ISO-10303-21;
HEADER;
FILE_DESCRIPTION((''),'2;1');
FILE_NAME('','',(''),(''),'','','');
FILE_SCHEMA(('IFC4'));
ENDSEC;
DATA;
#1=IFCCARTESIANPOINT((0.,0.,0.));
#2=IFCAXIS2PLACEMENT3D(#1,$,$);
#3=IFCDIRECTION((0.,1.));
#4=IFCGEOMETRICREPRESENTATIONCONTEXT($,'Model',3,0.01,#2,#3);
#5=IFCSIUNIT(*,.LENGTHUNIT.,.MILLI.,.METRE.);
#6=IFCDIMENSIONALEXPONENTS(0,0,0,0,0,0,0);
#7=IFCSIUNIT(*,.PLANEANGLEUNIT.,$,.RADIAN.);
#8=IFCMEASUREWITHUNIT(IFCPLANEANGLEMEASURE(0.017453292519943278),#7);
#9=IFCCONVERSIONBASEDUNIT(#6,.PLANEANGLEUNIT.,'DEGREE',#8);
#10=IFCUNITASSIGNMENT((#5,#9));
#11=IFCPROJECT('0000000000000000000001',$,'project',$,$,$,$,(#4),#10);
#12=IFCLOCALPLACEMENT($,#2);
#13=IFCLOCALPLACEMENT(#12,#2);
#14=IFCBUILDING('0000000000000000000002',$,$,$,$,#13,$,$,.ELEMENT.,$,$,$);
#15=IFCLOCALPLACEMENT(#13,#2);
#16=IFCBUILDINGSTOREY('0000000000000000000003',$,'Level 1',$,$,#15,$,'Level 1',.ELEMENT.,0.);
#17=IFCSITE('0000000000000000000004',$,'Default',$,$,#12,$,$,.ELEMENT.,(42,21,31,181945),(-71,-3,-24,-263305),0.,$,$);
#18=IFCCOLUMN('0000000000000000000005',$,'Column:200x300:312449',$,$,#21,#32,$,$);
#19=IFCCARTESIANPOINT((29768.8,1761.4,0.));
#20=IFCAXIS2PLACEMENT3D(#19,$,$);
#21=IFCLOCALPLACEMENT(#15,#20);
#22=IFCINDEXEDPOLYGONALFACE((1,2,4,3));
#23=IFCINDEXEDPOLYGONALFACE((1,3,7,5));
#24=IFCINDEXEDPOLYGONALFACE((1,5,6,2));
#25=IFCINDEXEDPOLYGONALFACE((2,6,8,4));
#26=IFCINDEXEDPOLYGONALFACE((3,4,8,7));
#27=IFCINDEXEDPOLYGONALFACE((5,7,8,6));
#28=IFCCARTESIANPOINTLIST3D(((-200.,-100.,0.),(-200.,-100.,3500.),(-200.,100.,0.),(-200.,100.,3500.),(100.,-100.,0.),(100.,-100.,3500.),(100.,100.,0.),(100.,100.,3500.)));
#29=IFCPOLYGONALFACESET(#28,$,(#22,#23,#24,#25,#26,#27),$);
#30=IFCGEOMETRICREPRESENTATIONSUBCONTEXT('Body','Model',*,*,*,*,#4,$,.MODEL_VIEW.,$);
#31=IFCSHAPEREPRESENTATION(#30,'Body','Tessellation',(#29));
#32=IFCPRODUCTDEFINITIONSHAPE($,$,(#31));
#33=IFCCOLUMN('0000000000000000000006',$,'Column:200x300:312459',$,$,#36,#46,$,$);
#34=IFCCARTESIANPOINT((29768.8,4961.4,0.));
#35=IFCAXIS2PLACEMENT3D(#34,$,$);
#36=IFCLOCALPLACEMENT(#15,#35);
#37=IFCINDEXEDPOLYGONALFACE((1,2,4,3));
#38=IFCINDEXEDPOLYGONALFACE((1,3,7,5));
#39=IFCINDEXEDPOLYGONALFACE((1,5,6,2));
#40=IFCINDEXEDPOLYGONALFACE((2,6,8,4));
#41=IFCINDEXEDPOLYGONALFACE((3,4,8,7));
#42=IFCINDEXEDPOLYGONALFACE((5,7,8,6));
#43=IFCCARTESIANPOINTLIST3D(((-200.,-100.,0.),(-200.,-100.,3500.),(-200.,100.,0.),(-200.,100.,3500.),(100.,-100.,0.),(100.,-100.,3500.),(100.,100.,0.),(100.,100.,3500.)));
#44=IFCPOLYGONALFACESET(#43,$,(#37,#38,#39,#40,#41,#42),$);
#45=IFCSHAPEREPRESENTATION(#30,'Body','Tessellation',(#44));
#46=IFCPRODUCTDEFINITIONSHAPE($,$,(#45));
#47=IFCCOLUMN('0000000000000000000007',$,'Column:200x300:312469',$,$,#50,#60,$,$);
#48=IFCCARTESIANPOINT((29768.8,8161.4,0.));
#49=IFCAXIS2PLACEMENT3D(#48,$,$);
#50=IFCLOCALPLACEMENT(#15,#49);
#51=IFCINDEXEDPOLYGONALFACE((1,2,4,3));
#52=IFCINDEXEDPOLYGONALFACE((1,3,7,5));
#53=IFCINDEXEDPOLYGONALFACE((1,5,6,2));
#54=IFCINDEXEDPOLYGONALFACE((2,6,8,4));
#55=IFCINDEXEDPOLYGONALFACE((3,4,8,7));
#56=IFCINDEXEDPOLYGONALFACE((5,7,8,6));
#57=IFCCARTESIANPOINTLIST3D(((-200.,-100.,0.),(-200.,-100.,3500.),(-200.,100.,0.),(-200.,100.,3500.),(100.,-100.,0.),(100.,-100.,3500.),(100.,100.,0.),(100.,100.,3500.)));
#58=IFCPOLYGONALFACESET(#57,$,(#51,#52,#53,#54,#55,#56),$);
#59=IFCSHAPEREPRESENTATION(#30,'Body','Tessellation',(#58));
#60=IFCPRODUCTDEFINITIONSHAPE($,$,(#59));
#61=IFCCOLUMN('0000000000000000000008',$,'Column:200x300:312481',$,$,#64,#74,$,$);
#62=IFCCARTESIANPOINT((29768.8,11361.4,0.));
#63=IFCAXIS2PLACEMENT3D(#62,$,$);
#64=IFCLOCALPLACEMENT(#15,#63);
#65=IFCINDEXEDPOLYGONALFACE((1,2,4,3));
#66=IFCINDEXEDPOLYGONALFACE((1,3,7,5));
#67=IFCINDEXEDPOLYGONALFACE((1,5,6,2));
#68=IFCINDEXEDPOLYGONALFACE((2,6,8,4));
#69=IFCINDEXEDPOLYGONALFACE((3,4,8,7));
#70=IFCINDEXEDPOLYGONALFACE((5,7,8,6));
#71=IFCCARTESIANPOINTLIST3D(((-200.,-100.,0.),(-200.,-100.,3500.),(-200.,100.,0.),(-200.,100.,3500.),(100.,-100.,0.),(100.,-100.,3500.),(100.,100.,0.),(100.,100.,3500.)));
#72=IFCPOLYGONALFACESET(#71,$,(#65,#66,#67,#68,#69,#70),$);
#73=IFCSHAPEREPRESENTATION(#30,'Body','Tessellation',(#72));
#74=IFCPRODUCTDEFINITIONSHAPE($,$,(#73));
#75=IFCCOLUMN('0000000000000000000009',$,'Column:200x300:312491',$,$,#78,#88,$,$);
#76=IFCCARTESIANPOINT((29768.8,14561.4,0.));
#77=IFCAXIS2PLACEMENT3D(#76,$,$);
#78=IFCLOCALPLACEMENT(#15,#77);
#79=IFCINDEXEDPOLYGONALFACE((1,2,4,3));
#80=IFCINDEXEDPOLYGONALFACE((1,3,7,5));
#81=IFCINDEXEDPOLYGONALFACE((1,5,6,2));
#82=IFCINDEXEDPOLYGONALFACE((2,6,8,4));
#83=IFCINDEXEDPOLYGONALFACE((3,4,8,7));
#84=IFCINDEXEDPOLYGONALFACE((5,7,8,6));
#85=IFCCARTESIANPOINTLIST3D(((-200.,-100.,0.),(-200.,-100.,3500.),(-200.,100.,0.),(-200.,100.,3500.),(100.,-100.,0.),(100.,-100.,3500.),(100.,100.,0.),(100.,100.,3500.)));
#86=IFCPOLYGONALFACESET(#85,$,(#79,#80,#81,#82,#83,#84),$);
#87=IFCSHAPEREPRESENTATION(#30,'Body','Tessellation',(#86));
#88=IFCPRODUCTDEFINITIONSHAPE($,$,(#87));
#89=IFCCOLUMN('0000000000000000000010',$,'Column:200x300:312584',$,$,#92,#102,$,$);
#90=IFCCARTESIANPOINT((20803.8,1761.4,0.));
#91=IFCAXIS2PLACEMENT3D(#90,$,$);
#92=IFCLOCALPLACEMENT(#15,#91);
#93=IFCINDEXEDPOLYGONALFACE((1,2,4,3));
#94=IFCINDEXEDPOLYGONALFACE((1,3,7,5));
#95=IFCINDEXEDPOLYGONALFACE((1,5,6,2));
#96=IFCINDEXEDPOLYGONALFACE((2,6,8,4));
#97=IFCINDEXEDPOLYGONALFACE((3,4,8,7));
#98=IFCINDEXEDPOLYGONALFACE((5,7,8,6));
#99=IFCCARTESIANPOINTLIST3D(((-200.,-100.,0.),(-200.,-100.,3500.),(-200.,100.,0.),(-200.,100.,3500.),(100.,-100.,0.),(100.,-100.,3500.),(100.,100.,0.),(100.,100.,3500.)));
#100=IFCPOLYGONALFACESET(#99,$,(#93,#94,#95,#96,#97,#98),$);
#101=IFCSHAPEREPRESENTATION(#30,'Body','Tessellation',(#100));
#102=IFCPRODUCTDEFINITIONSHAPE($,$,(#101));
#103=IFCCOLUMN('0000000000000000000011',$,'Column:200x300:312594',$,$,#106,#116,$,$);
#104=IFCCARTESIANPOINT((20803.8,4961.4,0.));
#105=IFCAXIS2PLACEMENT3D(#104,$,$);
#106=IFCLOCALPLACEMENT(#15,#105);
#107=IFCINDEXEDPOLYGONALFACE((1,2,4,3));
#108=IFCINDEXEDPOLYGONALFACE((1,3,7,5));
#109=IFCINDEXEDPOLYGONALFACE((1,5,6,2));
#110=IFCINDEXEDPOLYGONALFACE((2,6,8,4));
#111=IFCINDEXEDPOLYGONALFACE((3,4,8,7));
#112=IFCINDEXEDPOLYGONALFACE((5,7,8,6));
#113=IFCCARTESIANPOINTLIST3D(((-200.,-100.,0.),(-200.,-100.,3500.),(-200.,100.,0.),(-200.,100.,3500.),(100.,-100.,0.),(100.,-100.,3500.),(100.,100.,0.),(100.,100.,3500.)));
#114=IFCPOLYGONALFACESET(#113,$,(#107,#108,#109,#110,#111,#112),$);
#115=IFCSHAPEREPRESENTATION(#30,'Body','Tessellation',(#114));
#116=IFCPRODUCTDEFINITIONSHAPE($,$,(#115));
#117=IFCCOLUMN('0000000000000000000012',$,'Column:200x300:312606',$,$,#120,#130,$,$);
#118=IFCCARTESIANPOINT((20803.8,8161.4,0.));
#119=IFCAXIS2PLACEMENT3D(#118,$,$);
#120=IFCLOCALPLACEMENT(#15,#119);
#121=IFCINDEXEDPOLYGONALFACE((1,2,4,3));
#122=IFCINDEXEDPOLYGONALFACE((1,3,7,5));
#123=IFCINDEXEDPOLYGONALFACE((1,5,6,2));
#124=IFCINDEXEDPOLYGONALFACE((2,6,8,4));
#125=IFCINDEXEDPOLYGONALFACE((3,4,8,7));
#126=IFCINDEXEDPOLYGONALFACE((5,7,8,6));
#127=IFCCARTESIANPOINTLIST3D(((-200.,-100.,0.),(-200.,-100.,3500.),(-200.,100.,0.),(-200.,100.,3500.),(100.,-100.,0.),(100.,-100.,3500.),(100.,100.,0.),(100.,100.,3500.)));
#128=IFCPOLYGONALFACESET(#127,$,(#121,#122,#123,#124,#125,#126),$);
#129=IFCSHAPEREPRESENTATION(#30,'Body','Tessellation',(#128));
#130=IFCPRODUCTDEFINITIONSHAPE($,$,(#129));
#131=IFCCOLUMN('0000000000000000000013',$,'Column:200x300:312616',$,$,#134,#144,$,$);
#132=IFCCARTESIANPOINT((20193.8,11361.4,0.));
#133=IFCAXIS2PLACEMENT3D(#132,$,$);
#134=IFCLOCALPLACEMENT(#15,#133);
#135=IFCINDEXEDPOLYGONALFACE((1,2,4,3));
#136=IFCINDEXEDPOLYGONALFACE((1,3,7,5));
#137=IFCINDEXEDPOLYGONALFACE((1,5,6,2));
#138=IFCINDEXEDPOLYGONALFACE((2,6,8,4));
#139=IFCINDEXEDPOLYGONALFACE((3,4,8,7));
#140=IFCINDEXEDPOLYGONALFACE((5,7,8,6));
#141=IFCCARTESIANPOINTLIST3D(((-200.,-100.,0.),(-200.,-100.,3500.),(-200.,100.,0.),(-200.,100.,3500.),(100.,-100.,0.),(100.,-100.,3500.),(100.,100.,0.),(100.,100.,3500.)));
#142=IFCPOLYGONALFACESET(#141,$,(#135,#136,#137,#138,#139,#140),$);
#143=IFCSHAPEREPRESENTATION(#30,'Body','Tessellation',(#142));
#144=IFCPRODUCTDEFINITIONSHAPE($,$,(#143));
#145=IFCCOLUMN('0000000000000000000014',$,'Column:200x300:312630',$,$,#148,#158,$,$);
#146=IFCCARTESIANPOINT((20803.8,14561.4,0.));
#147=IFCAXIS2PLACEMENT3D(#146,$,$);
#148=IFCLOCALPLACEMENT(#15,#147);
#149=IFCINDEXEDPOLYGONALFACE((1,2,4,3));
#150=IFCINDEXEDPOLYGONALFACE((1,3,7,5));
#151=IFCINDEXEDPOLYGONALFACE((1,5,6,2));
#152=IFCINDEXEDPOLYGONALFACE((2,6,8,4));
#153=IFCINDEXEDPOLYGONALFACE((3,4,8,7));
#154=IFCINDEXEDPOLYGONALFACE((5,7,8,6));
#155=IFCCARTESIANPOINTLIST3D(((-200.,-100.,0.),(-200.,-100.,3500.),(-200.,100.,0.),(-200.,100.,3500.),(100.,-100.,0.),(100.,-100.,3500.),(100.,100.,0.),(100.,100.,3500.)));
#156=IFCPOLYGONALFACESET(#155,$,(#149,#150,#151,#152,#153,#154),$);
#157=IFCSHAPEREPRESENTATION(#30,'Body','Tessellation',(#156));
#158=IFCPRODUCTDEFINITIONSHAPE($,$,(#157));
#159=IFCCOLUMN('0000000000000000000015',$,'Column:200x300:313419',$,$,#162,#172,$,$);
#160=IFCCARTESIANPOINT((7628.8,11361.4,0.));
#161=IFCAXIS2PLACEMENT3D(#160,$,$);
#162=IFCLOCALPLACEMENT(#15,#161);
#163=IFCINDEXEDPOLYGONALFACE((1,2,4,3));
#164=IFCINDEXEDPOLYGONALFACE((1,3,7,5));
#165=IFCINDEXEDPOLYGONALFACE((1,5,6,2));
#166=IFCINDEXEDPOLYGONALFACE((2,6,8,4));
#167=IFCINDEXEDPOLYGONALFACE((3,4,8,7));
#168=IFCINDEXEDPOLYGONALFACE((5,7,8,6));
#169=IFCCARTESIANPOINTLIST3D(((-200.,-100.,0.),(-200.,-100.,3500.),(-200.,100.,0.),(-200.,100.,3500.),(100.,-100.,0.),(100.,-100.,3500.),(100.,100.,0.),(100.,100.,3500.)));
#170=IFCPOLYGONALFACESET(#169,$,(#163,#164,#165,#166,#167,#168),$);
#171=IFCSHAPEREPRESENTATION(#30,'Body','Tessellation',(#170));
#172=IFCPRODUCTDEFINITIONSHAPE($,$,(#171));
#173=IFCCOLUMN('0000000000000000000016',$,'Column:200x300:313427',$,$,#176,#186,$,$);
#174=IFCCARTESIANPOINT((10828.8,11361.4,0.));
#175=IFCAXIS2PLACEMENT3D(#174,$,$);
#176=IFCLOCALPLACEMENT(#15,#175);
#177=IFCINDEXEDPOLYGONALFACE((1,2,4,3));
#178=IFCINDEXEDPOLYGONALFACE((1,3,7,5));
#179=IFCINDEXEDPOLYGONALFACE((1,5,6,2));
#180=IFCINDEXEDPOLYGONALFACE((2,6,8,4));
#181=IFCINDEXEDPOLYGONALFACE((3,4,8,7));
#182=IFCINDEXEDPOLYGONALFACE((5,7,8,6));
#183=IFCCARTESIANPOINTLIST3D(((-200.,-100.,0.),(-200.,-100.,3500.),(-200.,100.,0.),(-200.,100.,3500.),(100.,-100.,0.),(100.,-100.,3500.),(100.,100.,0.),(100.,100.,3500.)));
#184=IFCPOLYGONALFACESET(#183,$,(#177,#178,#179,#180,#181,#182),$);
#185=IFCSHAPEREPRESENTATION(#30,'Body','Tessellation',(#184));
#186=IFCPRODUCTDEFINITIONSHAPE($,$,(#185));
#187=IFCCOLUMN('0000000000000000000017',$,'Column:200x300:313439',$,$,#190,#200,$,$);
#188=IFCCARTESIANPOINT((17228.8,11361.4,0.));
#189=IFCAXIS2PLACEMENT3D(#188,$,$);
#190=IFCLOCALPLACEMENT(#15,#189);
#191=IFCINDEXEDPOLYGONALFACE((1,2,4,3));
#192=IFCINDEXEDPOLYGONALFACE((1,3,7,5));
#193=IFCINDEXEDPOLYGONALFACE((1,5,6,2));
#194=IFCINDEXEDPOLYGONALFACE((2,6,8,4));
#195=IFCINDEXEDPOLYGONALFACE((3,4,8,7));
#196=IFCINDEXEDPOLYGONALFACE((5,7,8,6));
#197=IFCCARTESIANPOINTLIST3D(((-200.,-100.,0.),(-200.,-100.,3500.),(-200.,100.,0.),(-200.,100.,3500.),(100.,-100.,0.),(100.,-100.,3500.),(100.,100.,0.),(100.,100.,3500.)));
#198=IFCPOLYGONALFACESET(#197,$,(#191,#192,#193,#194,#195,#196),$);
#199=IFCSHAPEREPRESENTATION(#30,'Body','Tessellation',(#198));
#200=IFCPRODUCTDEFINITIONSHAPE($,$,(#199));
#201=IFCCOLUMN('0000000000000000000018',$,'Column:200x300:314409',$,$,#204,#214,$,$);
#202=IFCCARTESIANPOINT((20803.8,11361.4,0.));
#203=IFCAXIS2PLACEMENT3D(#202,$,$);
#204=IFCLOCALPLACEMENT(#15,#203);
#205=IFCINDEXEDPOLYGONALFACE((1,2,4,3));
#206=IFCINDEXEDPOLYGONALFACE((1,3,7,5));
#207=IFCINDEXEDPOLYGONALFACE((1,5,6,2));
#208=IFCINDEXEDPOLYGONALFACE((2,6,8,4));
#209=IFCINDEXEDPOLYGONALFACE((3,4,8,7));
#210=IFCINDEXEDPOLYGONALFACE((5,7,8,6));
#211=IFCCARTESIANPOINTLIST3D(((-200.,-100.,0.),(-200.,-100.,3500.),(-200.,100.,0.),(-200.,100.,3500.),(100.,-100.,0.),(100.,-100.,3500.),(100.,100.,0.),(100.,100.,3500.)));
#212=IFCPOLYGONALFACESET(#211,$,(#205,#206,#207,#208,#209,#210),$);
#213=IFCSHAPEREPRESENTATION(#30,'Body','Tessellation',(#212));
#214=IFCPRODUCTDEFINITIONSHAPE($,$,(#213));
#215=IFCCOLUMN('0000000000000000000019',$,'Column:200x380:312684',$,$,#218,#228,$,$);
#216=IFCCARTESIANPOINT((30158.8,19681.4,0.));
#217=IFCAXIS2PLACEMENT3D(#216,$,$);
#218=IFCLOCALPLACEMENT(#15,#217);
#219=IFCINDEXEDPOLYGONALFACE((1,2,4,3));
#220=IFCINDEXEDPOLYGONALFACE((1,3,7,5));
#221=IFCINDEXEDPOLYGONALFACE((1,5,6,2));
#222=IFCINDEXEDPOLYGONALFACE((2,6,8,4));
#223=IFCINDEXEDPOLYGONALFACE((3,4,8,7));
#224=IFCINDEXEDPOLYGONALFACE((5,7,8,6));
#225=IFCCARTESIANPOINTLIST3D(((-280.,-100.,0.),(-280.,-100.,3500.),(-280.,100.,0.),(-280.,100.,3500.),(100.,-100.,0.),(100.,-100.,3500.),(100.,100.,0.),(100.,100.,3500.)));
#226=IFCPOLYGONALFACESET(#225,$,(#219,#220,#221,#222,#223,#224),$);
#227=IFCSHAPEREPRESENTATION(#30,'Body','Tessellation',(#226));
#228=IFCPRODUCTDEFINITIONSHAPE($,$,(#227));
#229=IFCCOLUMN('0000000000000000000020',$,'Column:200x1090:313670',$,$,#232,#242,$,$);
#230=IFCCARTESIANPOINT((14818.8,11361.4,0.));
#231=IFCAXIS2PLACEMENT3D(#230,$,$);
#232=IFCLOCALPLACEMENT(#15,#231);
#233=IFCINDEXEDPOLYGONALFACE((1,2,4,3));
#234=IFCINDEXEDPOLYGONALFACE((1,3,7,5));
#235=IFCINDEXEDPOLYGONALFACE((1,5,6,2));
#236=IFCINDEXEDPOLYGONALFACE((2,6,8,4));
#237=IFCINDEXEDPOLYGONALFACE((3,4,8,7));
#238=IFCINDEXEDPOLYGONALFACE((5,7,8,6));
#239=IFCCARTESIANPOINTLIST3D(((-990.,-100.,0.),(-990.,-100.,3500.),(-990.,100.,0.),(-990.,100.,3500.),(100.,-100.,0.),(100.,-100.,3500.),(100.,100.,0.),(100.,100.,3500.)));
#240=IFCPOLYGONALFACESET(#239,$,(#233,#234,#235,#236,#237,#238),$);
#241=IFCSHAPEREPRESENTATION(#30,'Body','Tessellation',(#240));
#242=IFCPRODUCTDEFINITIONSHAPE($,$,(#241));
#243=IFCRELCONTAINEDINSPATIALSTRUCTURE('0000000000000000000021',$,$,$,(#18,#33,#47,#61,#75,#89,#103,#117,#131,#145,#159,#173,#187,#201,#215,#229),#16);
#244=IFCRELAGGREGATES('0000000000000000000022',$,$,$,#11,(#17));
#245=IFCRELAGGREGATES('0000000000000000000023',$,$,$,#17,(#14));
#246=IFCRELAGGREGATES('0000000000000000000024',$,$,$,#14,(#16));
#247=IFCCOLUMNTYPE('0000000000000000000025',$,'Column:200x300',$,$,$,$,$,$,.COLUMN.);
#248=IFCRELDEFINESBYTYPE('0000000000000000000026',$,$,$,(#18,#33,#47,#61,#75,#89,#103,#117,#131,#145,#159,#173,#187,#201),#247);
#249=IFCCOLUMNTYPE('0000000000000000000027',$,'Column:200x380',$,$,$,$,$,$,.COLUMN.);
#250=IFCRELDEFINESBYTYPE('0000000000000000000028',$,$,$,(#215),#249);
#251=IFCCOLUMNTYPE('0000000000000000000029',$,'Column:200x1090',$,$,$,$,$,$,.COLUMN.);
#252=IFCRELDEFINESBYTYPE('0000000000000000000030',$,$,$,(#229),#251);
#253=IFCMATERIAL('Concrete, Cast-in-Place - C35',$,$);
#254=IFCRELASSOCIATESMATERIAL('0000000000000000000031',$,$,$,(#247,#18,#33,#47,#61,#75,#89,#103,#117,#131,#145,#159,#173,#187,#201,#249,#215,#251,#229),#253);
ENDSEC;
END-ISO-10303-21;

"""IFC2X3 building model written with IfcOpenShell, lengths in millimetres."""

from ifc_helpers import new_model, entity, si_unit, converted_unit, direction, frame, frame_2d, origin, origin_2d_with_axis, place, context, subcontext, project, spatial, rectangle, extrude, source, transform, mapped, material, type_object, type_shapes, element, save


model = new_model("IFC2X3")

# Units and contexts
model_context = context("Model", 3, precision=0.01, world=origin(), true_north=direction((0.0, 1.0)))
body_context = subcontext(model_context, "Body", "Model", "MODEL_VIEW")
ifc_project = project(units=[si_unit("LENGTHUNIT", "METRE", prefix="MILLI"), converted_unit("PLANEANGLEUNIT", "DEGREE", entity("IfcPlaneAngleMeasure", 0.017453292519943278), si_unit("PLANEANGLEUNIT", "RADIAN"), dimensions=[0, 0, 0, 0, 0, 0, 0])], contexts=[model_context])

# Site, building, storey
site_placement = place(None, origin())
site = spatial("IfcSite", under=ifc_project, at=site_placement, Name="Default", CompositionType="ELEMENT", RefLatitude=(42, 21, 31, 181945), RefLongitude=(-71, -3, -24, -263305), RefElevation=0.0)
building_placement = place(site_placement, origin())
building = spatial("IfcBuilding", under=site, at=building_placement, CompositionType="ELEMENT")
storey_placement = place(building_placement, origin())
storey = spatial("IfcBuildingStorey", under=building, at=storey_placement, Name="Level 1", LongName="Level 1", CompositionType="ELEMENT", Elevation=0.0)

# Columns
ifc_material = material(Name="Concrete, Cast-in-Place - C35")
column_type_1 = type_object("IfcColumnType", Name="Column:200x300", PredefinedType="COLUMN", material=ifc_material)
shared_shape_1 = source(origin(), body_context, "Body", "SweptSolid", [
    extrude(rectangle(XDim=300.0, YDim=200.0, at=origin_2d_with_axis()), frame((-50.0, 0.0, 0.0), z_axis=(0.0, 0.0, 1.0), x_axis=(-1.0, 0.0, 0.0)), (0.0, 0.0, 1.0), 3500.0),
])
type_shapes(column_type_1, [shared_shape_1])
for number, where, name in (
    (1, (29768.8, 1761.4, 0.0), "Column:200x300:312449"),
    (2, (29768.8, 4961.4, 0.0), "Column:200x300:312459"),
    (3, (29768.8, 8161.4, 0.0), "Column:200x300:312469"),
    (4, (29768.8, 11361.4, 0.0), "Column:200x300:312481"),
    (5, (29768.8, 14561.4, 0.0), "Column:200x300:312491"),
    (6, (20803.8, 1761.4, 0.0), "Column:200x300:312584"),
    (7, (20803.8, 4961.4, 0.0), "Column:200x300:312594"),
    (8, (20803.8, 8161.4, 0.0), "Column:200x300:312606"),
    (9, (20193.8, 11361.4, 0.0), "Column:200x300:312616"),
    (10, (20803.8, 14561.4, 0.0), "Column:200x300:312630"),
    (11, (7628.8, 11361.4, 0.0), "Column:200x300:313419"),
    (12, (10828.8, 11361.4, 0.0), "Column:200x300:313427"),
    (13, (17228.8, 11361.4, 0.0), "Column:200x300:313439"),
    (14, (20803.8, 11361.4, 0.0), "Column:200x300:314409"),
):
    element("IfcColumn", number, at=place(storey_placement, frame(where)), inside=storey, type_object=column_type_1, material=ifc_material, Name=name, context=body_context, shape_type="MappedRepresentation", body=[
        mapped(shared_shape_1, transform((0.0, 0.0, 0.0), scale=1.0)),
    ])
column_type_2 = type_object("IfcColumnType", Name="Column:200x380", PredefinedType="COLUMN", material=ifc_material)
shared_shape_2 = source(origin(), body_context, "Body", "SweptSolid", [
    extrude(rectangle(XDim=380.0, YDim=200.0, at=origin_2d_with_axis()), frame((-90.0, 0.0, 0.0), z_axis=(0.0, 0.0, 1.0), x_axis=(-1.0, 0.0, 0.0)), (0.0, 0.0, 1.0), 3500.0),
])
type_shapes(column_type_2, [shared_shape_2])
column_1_placement = place(storey_placement, frame((30158.8, 19681.4, 0.0)))
element("IfcColumn", 15, at=column_1_placement, inside=storey, type_object=column_type_2, material=ifc_material, Name="Column:200x380:312684", context=body_context, shape_type="MappedRepresentation", body=[
    mapped(shared_shape_2, transform((0.0, 0.0, 0.0), scale=1.0)),
])
column_type_3 = type_object("IfcColumnType", Name="Column:200x1090", PredefinedType="COLUMN", material=ifc_material)
shared_shape_3 = source(origin(), body_context, "Body", "SweptSolid", [
    extrude(rectangle(XDim=1090.0, YDim=200.0, at=frame_2d((0.0, 0.0), x_axis=(1.0, 0.0))), frame((-445.0, 0.0, 0.0), z_axis=(0.0, 0.0, 1.0), x_axis=(-1.0, 0.0, 0.0)), (0.0, 0.0, 1.0), 3500.0),
])
type_shapes(column_type_3, [shared_shape_3])
column_2_placement = place(storey_placement, frame((14818.8, 11361.4, 0.0)))
element("IfcColumn", 16, at=column_2_placement, inside=storey, type_object=column_type_3, material=ifc_material, Name="Column:200x1090:313670", context=body_context, shape_type="MappedRepresentation", body=[
    mapped(shared_shape_3, transform((0.0, 0.0, 0.0), scale=1.0)),
])

save(model, "model.ifc")
